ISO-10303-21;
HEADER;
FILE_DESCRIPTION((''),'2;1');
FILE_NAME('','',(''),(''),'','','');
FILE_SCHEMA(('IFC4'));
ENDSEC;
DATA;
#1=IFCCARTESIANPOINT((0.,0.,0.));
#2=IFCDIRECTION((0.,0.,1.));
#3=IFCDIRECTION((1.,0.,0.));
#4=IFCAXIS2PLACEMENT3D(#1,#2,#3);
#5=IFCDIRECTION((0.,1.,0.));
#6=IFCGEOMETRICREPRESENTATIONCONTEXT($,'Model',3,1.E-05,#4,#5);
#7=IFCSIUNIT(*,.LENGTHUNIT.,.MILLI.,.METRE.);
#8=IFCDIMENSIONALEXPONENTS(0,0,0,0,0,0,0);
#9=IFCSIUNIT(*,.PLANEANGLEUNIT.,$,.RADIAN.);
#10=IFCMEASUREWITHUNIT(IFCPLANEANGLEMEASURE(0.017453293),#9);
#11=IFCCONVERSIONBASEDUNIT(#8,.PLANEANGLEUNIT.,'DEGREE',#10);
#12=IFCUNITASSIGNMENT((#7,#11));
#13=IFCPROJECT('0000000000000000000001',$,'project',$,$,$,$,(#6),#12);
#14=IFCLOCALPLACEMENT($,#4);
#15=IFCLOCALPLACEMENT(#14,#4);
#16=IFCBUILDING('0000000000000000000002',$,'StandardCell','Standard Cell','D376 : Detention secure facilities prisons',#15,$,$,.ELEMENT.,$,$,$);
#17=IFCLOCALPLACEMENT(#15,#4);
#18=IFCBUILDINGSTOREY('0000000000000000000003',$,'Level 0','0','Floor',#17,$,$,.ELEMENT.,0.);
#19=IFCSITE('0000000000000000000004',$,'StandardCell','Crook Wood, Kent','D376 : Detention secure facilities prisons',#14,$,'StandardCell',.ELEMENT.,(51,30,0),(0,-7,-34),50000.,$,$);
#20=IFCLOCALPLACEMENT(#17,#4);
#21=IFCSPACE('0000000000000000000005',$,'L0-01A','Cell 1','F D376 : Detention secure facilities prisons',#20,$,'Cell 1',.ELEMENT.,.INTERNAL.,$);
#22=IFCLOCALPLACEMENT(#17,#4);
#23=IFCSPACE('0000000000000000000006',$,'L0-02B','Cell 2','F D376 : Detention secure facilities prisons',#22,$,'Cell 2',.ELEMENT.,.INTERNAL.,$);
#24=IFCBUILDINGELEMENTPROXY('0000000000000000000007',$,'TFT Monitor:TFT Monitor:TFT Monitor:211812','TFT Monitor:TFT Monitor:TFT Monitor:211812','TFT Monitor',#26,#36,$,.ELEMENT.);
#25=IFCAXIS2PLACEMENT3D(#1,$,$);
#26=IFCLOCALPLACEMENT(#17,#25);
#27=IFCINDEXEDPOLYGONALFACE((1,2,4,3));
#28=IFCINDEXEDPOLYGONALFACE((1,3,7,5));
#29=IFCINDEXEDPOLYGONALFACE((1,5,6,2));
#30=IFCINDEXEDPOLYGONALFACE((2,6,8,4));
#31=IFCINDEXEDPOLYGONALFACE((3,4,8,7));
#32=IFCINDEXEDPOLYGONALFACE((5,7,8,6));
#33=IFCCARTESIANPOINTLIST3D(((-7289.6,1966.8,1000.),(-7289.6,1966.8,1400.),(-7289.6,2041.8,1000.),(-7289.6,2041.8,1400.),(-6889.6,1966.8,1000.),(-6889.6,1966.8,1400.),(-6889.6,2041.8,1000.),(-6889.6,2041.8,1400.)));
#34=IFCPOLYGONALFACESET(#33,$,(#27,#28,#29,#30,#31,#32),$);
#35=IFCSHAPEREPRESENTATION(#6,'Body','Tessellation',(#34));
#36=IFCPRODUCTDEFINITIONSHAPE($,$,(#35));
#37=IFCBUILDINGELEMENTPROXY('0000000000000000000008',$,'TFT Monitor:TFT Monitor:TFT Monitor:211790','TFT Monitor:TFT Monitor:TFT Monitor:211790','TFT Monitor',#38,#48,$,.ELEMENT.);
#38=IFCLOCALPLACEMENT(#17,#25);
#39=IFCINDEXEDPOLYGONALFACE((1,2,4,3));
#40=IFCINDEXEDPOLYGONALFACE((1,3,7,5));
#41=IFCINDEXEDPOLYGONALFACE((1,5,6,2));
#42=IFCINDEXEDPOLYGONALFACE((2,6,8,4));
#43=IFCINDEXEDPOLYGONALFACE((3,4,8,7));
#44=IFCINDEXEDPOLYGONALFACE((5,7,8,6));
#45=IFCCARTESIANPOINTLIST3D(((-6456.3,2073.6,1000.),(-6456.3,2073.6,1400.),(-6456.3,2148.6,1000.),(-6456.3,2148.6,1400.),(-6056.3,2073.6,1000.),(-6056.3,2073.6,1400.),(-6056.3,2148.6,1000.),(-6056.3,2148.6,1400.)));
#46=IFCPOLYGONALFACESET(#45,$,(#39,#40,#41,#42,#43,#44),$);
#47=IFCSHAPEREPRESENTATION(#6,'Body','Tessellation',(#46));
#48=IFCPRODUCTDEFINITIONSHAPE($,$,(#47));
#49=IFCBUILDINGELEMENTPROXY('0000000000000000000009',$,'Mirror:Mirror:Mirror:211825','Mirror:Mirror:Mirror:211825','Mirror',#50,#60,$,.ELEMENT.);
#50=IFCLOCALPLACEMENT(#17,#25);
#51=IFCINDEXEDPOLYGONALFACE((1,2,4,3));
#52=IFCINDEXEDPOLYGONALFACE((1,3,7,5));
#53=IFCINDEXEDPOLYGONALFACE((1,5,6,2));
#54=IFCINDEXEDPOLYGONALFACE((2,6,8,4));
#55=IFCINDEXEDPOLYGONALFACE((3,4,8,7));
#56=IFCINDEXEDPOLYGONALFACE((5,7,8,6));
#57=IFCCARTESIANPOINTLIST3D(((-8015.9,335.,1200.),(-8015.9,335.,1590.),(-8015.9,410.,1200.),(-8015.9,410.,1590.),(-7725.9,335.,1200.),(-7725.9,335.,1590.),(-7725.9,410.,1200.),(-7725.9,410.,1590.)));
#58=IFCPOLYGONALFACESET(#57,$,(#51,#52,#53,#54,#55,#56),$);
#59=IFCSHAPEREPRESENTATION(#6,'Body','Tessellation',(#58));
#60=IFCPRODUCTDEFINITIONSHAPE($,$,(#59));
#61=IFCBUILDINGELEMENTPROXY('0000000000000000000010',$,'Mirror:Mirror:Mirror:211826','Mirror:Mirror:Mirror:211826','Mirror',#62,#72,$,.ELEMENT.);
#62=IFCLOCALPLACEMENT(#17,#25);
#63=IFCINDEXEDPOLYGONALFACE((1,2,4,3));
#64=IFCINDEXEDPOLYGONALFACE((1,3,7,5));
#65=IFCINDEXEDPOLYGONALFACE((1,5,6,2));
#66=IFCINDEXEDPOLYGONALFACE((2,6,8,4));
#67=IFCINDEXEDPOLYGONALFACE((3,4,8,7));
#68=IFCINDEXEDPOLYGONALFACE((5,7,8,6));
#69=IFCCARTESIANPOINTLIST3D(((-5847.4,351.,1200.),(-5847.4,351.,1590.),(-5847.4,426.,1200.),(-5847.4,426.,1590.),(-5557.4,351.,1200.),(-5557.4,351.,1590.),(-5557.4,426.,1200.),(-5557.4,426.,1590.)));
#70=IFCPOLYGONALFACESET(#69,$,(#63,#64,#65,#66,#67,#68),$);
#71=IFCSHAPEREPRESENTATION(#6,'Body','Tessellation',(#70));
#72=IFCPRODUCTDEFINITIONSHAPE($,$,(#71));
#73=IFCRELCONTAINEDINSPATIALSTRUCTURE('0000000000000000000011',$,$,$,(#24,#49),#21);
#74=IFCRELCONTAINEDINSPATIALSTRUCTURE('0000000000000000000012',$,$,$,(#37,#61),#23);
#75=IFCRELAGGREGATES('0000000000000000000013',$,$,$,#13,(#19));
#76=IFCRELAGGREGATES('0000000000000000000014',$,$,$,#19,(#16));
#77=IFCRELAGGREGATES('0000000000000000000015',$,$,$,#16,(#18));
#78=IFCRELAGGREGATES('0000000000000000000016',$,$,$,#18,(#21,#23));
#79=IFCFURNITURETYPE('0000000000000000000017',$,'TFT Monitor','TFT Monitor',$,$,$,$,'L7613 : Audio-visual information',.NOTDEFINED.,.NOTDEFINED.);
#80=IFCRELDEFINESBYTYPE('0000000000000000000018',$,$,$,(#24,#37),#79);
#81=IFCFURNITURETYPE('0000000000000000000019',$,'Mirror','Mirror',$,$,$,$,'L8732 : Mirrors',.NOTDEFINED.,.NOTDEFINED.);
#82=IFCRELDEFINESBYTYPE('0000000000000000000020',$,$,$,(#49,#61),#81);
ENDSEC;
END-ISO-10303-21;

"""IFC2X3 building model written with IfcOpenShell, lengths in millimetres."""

from ifc_helpers import new_model, entity, si_unit, converted_unit, direction, frame, frame_2d, origin, origin_with_axes, place, context, project, spatial, rectangle, extrude, source, transform, mapped, type_object, type_shapes, element, save


model = new_model("IFC2X3")

# Units and contexts
model_context = context("Model", 3, precision=1e-05, world=origin_with_axes(), true_north=direction((0.0, 1.0, 0.0)))
ifc_project = project(units=[si_unit("LENGTHUNIT", "METRE", prefix="MILLI"), converted_unit("PLANEANGLEUNIT", "DEGREE", entity("IfcPlaneAngleMeasure", 0.017453293), si_unit("PLANEANGLEUNIT", "RADIAN"), dimensions=[0, 0, 0, 0, 0, 0, 0])], contexts=[model_context])

# Site, building, storey
site_placement = place(None, origin_with_axes())
site = spatial("IfcSite", under=ifc_project, at=site_placement, Name="StandardCell", Description="Crook Wood, Kent", ObjectType="D376 : Detention secure facilities prisons", LongName="StandardCell", CompositionType="ELEMENT", RefLatitude=(51, 30, 0), RefLongitude=(0, -7, -34), RefElevation=50000.0)
building_placement = place(site_placement, origin_with_axes())
building = spatial("IfcBuilding", under=site, at=building_placement, Name="StandardCell", Description="Standard Cell", ObjectType="D376 : Detention secure facilities prisons", CompositionType="ELEMENT")
storey_placement = place(building_placement, origin_with_axes())
storey = spatial("IfcBuildingStorey", under=building, at=storey_placement, Name="Level 0", Description="0", ObjectType="Floor", CompositionType="ELEMENT", Elevation=0.0)

# Shared definitions
space_1_placement = place(storey_placement, origin_with_axes())
space_1 = spatial("IfcSpace", under=storey, at=space_1_placement, Name="L0-01A", Description="Cell 1", ObjectType="F D376 : Detention secure facilities prisons", LongName="Cell 1", CompositionType="ELEMENT", InteriorOrExteriorSpace="INTERNAL")

# Shared definitions
space_2_placement = place(storey_placement, origin_with_axes())
space_2 = spatial("IfcSpace", under=storey, at=space_2_placement, Name="L0-02B", Description="Cell 2", ObjectType="F D376 : Detention secure facilities prisons", LongName="Cell 2", CompositionType="ELEMENT", InteriorOrExteriorSpace="INTERNAL")

# Building element proxies
furniture_type_1 = type_object("IfcFurnitureType", Name="TFT Monitor", Description="TFT Monitor", ElementType="L7613 : Audio-visual information", AssemblyPlace="NOTDEFINED")
shared_shape_1 = source(origin(), model_context, "Body", "SweptSolid", [
    extrude(rectangle(XDim=400.0, YDim=75.0, at=frame_2d((200.0, 37.5), x_axis=(1.0, 0.0))), origin_with_axes(), (0.0, 0.0, 1.0), 400.0),
])
type_shapes(furniture_type_1, [shared_shape_1])
proxy_1_placement = place(space_1_placement, frame((-7289.6, 1966.8, 1000.0), z_axis=(0.0, 0.0, 1.0), x_axis=(1.0, 0.0, 0.0)))
element("IfcBuildingElementProxy", 1, at=proxy_1_placement, inside=space_1, type_object=furniture_type_1, Name="TFT Monitor:TFT Monitor:TFT Monitor:211812", Description="TFT Monitor:TFT Monitor:TFT Monitor:211812", ObjectType="TFT Monitor", CompositionType="ELEMENT", context=model_context, shape_type="MappedRepresentation", body=[
    mapped(shared_shape_1, transform((0.0, 0.0, 0.0))),
])
proxy_2_placement = place(space_2_placement, frame((-6456.3, 2073.6, 1000.0), z_axis=(0.0, 0.0, 1.0), x_axis=(1.0, 0.0, 0.0)))
element("IfcBuildingElementProxy", 2, at=proxy_2_placement, inside=space_2, type_object=furniture_type_1, Name="TFT Monitor:TFT Monitor:TFT Monitor:211790", Description="TFT Monitor:TFT Monitor:TFT Monitor:211790", ObjectType="TFT Monitor", CompositionType="ELEMENT", context=model_context, shape_type="MappedRepresentation", body=[
    mapped(shared_shape_1, transform((0.0, 0.0, 0.0))),
])
furniture_type_2 = type_object("IfcFurnitureType", Name="Mirror", Description="Mirror", ElementType="L8732 : Mirrors", AssemblyPlace="NOTDEFINED")
shared_shape_2 = source(origin(), model_context, "Body", "SweptSolid", [
    extrude(rectangle(XDim=290.0, YDim=75.0, at=frame_2d((145.0, 37.5), x_axis=(1.0, 0.0))), origin_with_axes(), (0.0, 0.0, 1.0), 390.0),
])
type_shapes(furniture_type_2, [shared_shape_2])
proxy_3_placement = place(space_1_placement, frame((-8015.9, 335.0, 1200.0), z_axis=(0.0, 0.0, 1.0), x_axis=(1.0, 0.0, 0.0)))
element("IfcBuildingElementProxy", 3, at=proxy_3_placement, inside=space_1, type_object=furniture_type_2, Name="Mirror:Mirror:Mirror:211825", Description="Mirror:Mirror:Mirror:211825", ObjectType="Mirror", CompositionType="ELEMENT", context=model_context, shape_type="MappedRepresentation", body=[
    mapped(shared_shape_2, transform((0.0, 0.0, 0.0))),
])
proxy_4_placement = place(space_2_placement, frame((-5847.4, 351.0, 1200.0), z_axis=(0.0, 0.0, 1.0), x_axis=(1.0, 0.0, 0.0)))
element("IfcBuildingElementProxy", 4, at=proxy_4_placement, inside=space_2, type_object=furniture_type_2, Name="Mirror:Mirror:Mirror:211826", Description="Mirror:Mirror:Mirror:211826", ObjectType="Mirror", CompositionType="ELEMENT", context=model_context, shape_type="MappedRepresentation", body=[
    mapped(shared_shape_2, transform((0.0, 0.0, 0.0))),
])

save(model, "model.ifc")
